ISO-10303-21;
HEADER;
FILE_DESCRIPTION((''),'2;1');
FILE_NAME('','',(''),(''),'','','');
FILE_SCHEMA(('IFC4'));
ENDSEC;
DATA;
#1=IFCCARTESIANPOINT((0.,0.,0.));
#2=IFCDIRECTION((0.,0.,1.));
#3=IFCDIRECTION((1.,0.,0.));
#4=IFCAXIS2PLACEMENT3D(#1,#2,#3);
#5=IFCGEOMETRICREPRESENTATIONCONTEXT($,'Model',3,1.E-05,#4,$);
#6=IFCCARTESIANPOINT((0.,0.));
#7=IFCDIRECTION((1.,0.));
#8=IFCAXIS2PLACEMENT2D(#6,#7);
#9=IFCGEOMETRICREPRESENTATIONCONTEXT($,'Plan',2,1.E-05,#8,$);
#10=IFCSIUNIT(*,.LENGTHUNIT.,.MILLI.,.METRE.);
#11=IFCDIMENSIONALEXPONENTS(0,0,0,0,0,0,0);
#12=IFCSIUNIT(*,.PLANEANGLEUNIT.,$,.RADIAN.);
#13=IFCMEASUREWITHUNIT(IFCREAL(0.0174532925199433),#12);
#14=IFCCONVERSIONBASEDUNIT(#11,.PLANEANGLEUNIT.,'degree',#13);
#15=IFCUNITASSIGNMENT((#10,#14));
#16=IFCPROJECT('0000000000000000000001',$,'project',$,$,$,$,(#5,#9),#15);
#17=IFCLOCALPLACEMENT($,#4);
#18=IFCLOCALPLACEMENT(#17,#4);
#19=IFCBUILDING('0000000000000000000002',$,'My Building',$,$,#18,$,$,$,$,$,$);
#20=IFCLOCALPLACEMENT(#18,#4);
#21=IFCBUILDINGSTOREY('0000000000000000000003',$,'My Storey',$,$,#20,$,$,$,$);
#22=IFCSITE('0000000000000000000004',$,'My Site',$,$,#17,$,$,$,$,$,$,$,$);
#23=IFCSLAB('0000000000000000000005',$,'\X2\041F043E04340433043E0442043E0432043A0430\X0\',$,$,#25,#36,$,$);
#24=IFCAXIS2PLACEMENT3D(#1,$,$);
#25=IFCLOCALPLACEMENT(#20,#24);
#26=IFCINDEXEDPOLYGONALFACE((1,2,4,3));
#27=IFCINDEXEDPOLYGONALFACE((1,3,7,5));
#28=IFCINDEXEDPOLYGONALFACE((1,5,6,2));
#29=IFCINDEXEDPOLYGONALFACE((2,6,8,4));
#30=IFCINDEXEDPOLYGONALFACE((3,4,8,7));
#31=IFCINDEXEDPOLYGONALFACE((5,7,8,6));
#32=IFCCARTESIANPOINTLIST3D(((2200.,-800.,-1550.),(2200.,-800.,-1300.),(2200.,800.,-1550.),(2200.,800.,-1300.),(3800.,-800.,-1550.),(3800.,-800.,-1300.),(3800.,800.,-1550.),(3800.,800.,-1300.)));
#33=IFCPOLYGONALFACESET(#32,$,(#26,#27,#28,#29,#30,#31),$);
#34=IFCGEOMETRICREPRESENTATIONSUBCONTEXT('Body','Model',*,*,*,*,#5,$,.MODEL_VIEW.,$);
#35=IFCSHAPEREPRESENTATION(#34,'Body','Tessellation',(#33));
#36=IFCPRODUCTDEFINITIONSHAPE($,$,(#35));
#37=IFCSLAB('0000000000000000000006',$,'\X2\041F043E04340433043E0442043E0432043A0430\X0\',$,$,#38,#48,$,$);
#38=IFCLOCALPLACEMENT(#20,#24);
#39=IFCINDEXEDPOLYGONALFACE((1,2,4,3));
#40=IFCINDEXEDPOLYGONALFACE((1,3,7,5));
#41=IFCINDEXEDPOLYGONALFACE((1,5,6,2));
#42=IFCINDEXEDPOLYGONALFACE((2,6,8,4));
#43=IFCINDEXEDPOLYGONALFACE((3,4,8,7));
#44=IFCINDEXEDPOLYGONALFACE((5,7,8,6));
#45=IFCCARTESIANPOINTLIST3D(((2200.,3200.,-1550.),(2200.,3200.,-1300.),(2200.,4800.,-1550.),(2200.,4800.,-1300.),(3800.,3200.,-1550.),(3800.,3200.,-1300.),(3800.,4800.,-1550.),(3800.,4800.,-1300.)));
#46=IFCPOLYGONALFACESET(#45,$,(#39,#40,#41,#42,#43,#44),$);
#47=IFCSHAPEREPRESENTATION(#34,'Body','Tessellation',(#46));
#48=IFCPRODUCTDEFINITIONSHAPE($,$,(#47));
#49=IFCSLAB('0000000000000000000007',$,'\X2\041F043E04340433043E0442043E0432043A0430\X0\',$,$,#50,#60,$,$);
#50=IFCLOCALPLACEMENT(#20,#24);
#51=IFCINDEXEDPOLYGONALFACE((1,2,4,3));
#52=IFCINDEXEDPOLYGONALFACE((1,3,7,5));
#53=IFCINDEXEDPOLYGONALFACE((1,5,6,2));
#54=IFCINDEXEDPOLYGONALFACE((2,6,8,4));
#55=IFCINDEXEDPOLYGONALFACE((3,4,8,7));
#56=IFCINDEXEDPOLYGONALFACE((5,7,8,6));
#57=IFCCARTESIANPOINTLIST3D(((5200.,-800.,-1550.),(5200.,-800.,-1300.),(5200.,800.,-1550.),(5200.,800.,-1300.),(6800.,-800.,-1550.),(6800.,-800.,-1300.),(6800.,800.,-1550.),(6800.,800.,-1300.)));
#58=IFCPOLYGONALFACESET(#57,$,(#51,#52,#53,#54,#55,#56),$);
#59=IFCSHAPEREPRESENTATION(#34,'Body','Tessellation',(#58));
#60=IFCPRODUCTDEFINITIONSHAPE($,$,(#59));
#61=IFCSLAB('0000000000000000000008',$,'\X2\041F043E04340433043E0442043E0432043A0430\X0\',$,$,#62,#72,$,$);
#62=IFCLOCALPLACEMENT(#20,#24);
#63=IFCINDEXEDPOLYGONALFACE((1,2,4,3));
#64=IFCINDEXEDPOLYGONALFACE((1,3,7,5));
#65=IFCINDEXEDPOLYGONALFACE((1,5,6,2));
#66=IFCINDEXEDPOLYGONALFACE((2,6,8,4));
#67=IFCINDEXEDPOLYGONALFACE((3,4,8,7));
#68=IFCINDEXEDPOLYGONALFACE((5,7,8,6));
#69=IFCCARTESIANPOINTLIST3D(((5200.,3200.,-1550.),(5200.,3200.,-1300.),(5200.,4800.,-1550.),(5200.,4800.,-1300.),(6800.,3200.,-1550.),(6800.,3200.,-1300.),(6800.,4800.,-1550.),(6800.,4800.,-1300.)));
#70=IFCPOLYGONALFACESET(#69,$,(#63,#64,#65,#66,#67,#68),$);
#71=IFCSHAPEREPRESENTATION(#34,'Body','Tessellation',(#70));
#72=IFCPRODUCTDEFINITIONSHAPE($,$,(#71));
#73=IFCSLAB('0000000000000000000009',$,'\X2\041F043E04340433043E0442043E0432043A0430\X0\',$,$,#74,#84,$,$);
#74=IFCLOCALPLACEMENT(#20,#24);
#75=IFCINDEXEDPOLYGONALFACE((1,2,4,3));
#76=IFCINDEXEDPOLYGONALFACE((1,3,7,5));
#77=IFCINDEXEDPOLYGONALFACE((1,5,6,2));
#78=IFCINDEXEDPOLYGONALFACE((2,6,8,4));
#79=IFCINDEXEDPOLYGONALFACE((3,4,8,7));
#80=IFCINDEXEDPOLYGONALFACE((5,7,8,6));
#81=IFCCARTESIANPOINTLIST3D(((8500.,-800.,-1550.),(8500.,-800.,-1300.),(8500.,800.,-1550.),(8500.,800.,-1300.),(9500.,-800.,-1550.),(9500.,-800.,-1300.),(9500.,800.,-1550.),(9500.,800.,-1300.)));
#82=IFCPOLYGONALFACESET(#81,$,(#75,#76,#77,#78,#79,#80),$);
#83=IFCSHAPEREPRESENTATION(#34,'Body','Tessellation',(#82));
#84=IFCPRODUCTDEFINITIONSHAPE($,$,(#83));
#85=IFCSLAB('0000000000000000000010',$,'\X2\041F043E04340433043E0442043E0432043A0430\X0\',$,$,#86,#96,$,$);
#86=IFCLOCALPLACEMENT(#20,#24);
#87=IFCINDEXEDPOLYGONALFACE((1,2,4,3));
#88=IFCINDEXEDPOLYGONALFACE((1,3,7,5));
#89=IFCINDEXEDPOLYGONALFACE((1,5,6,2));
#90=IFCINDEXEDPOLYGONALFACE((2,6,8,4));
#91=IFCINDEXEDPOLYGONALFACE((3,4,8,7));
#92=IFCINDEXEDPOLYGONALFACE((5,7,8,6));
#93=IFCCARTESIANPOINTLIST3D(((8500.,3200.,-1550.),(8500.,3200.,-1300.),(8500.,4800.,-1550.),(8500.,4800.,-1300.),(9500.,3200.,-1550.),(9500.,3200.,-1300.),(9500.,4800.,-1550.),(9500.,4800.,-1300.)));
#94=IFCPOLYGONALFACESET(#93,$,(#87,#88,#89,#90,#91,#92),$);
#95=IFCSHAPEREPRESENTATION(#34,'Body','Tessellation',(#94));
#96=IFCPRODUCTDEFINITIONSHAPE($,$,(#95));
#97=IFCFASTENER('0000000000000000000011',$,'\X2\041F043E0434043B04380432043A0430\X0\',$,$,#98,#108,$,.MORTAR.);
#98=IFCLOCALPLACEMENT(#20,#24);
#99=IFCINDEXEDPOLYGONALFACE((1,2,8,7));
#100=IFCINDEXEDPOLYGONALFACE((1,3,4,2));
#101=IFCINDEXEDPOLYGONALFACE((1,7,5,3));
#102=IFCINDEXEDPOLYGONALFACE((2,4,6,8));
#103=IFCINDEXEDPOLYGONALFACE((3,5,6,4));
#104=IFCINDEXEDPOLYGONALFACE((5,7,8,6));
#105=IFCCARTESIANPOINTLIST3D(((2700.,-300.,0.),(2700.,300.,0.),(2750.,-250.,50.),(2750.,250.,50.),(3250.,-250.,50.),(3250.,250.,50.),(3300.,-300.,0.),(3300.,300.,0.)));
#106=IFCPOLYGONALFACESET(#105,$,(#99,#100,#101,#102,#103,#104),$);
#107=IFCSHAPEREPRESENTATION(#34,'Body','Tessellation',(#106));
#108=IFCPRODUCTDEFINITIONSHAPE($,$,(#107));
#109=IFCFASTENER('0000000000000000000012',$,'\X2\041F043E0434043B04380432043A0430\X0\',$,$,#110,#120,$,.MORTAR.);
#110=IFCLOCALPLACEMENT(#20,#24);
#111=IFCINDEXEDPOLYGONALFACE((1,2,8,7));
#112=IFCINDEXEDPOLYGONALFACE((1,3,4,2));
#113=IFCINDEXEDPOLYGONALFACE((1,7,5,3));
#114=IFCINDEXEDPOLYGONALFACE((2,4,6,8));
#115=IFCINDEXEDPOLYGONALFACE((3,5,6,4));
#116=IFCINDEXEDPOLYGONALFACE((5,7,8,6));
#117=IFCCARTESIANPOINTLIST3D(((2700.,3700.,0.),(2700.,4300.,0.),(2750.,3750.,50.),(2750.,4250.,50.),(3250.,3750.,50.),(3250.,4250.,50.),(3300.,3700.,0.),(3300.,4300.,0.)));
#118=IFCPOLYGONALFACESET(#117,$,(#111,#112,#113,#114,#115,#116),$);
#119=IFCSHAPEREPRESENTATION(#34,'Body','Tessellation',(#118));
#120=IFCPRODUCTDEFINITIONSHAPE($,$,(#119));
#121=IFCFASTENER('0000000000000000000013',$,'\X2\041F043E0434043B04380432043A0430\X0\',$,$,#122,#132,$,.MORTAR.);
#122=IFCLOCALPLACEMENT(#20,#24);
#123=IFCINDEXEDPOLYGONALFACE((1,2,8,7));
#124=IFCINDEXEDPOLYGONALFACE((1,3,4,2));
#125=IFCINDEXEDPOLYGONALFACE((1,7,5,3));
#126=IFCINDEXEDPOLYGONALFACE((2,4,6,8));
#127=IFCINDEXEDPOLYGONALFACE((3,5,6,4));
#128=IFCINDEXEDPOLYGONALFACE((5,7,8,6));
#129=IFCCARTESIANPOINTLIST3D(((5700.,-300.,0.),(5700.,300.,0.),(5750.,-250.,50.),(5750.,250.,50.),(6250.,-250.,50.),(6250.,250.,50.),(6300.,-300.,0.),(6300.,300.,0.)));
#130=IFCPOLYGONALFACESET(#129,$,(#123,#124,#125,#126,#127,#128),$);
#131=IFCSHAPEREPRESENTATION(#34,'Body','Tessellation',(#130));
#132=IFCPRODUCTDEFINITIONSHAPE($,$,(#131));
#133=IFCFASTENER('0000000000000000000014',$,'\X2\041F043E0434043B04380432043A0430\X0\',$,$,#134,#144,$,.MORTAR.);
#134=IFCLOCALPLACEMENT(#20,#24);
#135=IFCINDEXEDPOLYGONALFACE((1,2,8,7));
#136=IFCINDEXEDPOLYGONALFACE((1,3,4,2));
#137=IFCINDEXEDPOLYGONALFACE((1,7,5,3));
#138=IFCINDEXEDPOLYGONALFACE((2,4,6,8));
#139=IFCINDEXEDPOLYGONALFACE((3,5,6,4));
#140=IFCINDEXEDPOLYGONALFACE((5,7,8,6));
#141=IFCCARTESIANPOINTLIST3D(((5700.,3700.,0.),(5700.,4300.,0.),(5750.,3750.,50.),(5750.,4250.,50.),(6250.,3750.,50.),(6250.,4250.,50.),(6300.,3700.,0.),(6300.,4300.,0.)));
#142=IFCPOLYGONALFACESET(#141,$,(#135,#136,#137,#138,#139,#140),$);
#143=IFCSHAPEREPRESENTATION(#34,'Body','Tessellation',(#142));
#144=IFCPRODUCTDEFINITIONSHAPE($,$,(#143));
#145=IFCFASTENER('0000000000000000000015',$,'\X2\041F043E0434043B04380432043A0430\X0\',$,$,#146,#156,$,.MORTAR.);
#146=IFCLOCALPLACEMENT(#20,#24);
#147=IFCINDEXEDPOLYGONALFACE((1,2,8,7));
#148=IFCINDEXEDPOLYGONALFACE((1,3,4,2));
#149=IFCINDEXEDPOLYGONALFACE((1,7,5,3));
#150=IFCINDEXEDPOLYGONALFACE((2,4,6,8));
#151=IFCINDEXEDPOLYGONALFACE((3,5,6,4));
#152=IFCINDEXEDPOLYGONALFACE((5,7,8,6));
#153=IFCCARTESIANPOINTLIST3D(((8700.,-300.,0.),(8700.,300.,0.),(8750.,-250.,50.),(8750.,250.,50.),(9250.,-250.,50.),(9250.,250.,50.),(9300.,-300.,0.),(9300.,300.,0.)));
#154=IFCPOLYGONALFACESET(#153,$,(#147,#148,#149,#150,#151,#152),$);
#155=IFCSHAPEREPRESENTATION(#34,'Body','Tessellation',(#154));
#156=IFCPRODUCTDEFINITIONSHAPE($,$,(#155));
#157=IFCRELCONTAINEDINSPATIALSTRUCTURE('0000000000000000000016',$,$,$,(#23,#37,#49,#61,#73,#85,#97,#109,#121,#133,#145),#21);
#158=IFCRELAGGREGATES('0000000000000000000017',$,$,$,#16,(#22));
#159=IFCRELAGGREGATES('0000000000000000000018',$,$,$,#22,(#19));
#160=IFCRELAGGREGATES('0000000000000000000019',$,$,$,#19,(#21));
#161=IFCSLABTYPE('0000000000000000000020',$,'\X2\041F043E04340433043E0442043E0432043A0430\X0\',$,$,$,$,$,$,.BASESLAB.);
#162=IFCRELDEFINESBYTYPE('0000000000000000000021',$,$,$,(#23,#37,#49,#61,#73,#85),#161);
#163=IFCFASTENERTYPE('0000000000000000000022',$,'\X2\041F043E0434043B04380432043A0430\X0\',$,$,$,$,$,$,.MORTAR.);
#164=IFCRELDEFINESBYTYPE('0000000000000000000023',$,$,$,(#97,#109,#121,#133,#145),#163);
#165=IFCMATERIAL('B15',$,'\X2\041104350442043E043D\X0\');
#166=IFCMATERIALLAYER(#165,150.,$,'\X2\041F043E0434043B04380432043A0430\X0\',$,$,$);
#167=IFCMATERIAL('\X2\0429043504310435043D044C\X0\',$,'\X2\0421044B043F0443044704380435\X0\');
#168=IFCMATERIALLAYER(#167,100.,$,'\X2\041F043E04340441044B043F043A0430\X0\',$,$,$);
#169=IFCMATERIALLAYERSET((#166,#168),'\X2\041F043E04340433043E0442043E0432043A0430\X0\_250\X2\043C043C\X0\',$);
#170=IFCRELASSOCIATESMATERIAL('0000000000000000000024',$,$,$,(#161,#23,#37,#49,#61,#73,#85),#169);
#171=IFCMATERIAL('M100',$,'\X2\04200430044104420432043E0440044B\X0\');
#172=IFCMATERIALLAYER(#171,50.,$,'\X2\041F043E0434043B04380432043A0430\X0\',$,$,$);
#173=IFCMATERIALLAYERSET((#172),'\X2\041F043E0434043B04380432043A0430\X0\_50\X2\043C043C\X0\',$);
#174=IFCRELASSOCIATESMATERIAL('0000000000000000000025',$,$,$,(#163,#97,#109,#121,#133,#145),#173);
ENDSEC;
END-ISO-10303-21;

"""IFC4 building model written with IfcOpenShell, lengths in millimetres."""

from ifc_helpers import new_model, entity, si_unit, converted_unit, frame, origin_with_axes, origin_2d_with_axis, place, context, subcontext, project, spatial, line, indexed_curve, outline, extrude, clip, halfspace, material, layer, layer_set, layer_usage, type_object, element, save


model = new_model("IFC4")

# Units and contexts
model_context = context("Model", 3, precision=1e-05, world=origin_with_axes())
plan_context = context("Plan", 2, precision=1e-05, world=origin_2d_with_axis())
body_context = subcontext(model_context, "Body", "Model", "MODEL_VIEW")
ifc_project = project(units=[si_unit("LENGTHUNIT", "METRE", prefix="MILLI"), converted_unit("PLANEANGLEUNIT", "degree", entity("IfcReal", 0.0174532925199433), si_unit("PLANEANGLEUNIT", "RADIAN"), dimensions=[0, 0, 0, 0, 0, 0, 0])], contexts=[model_context, plan_context])

# Site, building, storey
site_placement = place(None, origin_with_axes())
site = spatial("IfcSite", under=ifc_project, at=site_placement, Name="My Site")
building_placement = place(site_placement, origin_with_axes())
building = spatial("IfcBuilding", under=site, at=building_placement, Name="My Building")
storey_placement = place(building_placement, origin_with_axes())
storey = spatial("IfcBuildingStorey", under=building, at=storey_placement, Name="My Storey")

# Slabs
ifc_material_1 = material(Name="B15", Category="Бетон")
ifc_layer_1 = layer(ifc_material_1, 150.0, Name="Подливка")
ifc_material_2 = material(Name="Щебень", Category="Сыпучие")
ifc_layer_2 = layer(ifc_material_2, 100.0, Name="Подсыпка")
ifc_layer_set_1 = layer_set([ifc_layer_1, ifc_layer_2], Name="Подготовка_250мм")
ifc_layer_usage_1 = layer_usage(ifc_layer_set_1, "AXIS3", "NEGATIVE", 0.0)
slab_type = type_object("IfcSlabType", Name="Подготовка", PredefinedType="BASESLAB", material=ifc_layer_set_1)
slab_1_placement = place(storey_placement, frame((3000.0, 0.0, -1550.0), z_axis=(0.0, 0.0, 1.0), x_axis=(1.0, 0.0, 0.0)))
element("IfcSlab", 1, at=slab_1_placement, inside=storey, type_object=slab_type, material=ifc_layer_usage_1, Name="Подготовка", context=body_context, shape_type="SweptSolid", body=[
    extrude(outline(indexed_curve([(800.0, 800.0), (800.0, -800.0), (-800.0, -800.0), (-800.0, 800.0)], segments=[line(3, 2), line(2, 1), line(1, 4), line(4, 3)], self_intersect=False)), None, (0.0, 0.0, 1.0), 250.0),
])
slab_2_placement = place(storey_placement, frame((3000.0, 4000.0, -1550.0), z_axis=(0.0, 0.0, 1.0), x_axis=(1.0, 0.0, 0.0)))
element("IfcSlab", 2, at=slab_2_placement, inside=storey, type_object=slab_type, material=ifc_layer_usage_1, Name="Подготовка", context=body_context, shape_type="SweptSolid", body=[
    extrude(outline(indexed_curve([(-800.0, -800.0), (800.0, -800.0), (800.0, 800.0), (-800.0, 800.0)], segments=[line(3, 2), line(2, 1), line(1, 4), line(4, 3)], self_intersect=False)), None, (0.0, 0.0, 1.0), 250.0),
])
for number, where, z_axis, x_axis, name in (
    (3, (6000.0, 0.0, -1550.0), (0.0, 0.0, 1.0), (1.0, 0.0, 0.0), "Подготовка"),
    (4, (6000.0, 4000.0, -1550.0), (0.0, 0.0, 1.0), (1.0, 0.0, 0.0), "Подготовка"),
):
    element("IfcSlab", number, at=place(storey_placement, frame(where, z_axis=z_axis, x_axis=x_axis)), inside=storey, type_object=slab_type, material=ifc_layer_usage_1, Name=name, context=body_context, shape_type="SweptSolid", body=[
        extrude(outline(indexed_curve([(800.0, 800.0), (800.0, -800.0), (-800.0, -800.0), (-800.0, 800.0)], segments=[line(3, 2), line(2, 1), line(1, 4), line(4, 3)], self_intersect=False)), None, (0.0, 0.0, 1.0), 250.0),
    ])
slab_3_placement = place(storey_placement, frame((9000.0, 0.0, -1550.0), z_axis=(0.0, 0.0, 1.0), x_axis=(1.0, 0.0, 0.0)))
element("IfcSlab", 5, at=slab_3_placement, inside=storey, type_object=slab_type, material=ifc_layer_usage_1, Name="Подготовка", context=body_context, shape_type="SweptSolid", body=[
    extrude(outline(indexed_curve([(500.0, 800.0), (500.0, -800.0), (-500.0, -800.0), (-500.0, 800.0)], segments=[line(3, 2), line(2, 1), line(1, 4), line(4, 3)], self_intersect=False)), None, (0.0, 0.0, 1.0), 250.0),
])
slab_4_placement = place(storey_placement, frame((9000.0, 4000.0, -1550.0), z_axis=(0.0, 0.0, 1.0), x_axis=(1.0, 0.0, 0.0)))
element("IfcSlab", 6, at=slab_4_placement, inside=storey, type_object=slab_type, material=ifc_layer_usage_1, Name="Подготовка", context=body_context, shape_type="SweptSolid", body=[
    extrude(outline(indexed_curve([(-500.0, -800.0), (500.0, -800.0), (500.0, 800.0), (-500.0, 800.0)], segments=[line(3, 2), line(2, 1), line(1, 4), line(4, 3)], self_intersect=False)), None, (0.0, 0.0, 1.0), 250.0),
])

# Fasteners
ifc_material_3 = material(Name="M100", Category="Растворы")
ifc_layer_3 = layer(ifc_material_3, 50.0, Name="Подливка")
ifc_layer_set_2 = layer_set([ifc_layer_3], Name="Подливка_50мм")
ifc_layer_usage_2 = layer_usage(ifc_layer_set_2, "AXIS3", "POSITIVE", 0.0)
fastener_type = type_object("IfcFastenerType", Name="Подливка", PredefinedType="MORTAR", material=ifc_layer_set_2)
placement = place(storey_placement, frame((3000.0, 0.0, 0.0), z_axis=(0.0, 0.0, 1.0), x_axis=(1.0, 0.0, 0.0)))
element("IfcFastener", 7, at=placement, inside=storey, type_object=fastener_type, material=ifc_layer_usage_2, Name="Подливка", PredefinedType="MORTAR", context=body_context, shape_type="Clipping", body=[
    clip(clip(clip(clip(extrude(outline(indexed_curve([(-300.0, -300.0), (300.0, -300.0), (300.0, 300.0), (-300.0, 300.0)], segments=[line(3, 2), line(2, 1), line(1, 4), line(4, 3)], self_intersect=False)), None, (0.0, 0.0, 1.0), 50.0), halfspace(frame((-53.6, 200.0, 353.6), z_axis=(0.707107, 0.0, 0.707107), x_axis=(0.707107, 0.0, -0.707107)), False)), halfspace(frame((-200.0, -53.6, 353.6), z_axis=(0.0, 0.707107, 0.707107), x_axis=(0.0, 0.707107, -0.707107)), False)), halfspace(frame((200.0, 53.6, 353.6), z_axis=(0.0, -0.707107, 0.707107), x_axis=(0.0, -0.707107, -0.707107)), False)), halfspace(frame((53.6, 200.0, 353.6), z_axis=(-0.707107, 0.0, 0.707107), x_axis=(-0.707107, 0.0, -0.707107)), False)),
])
fastener_1_placement = place(storey_placement, frame((3000.0, 4000.0, 0.0), z_axis=(0.0, 0.0, 1.0), x_axis=(1.0, 0.0, 0.0)))
element("IfcFastener", 8, at=fastener_1_placement, inside=storey, type_object=fastener_type, material=ifc_layer_usage_2, Name="Подливка", PredefinedType="MORTAR", context=body_context, shape_type="Clipping", body=[
    clip(clip(clip(clip(extrude(outline(indexed_curve([(-300.0, -300.0), (300.0, -300.0), (300.0, 300.0), (-300.0, 300.0)], segments=[line(3, 2), line(2, 1), line(1, 4), line(4, 3)], self_intersect=False)), None, (0.0, 0.0, 1.0), 50.0), halfspace(frame((-53.6, 200.0, 353.6), z_axis=(0.707107, 0.0, 0.707107), x_axis=(0.707107, 0.0, -0.707107)), False)), halfspace(frame((-200.0, -53.6, 353.6), z_axis=(0.0, 0.707107, 0.707107), x_axis=(0.0, 0.707107, -0.707107)), False)), halfspace(frame((200.0, 53.6, 353.6), z_axis=(0.0, -0.707107, 0.707107), x_axis=(0.0, -0.707107, -0.707107)), False)), halfspace(frame((53.6, 200.0, 353.6), z_axis=(-0.707107, 0.0, 0.707107), x_axis=(-0.707107, 0.0, -0.707107)), False)),
])
fastener_2_placement = place(storey_placement, frame((6000.0, 0.0, 0.0), z_axis=(0.0, 0.0, 1.0), x_axis=(1.0, 0.0, 0.0)))
element("IfcFastener", 9, at=fastener_2_placement, inside=storey, type_object=fastener_type, material=ifc_layer_usage_2, Name="Подливка", PredefinedType="MORTAR", context=body_context, shape_type="Clipping", body=[
    clip(clip(clip(clip(extrude(outline(indexed_curve([(-300.0, -300.0), (300.0, -300.0), (300.0, 300.0), (-300.0, 300.0)], segments=[line(3, 2), line(2, 1), line(1, 4), line(4, 3)], self_intersect=False)), None, (0.0, 0.0, 1.0), 50.0), halfspace(frame((-53.6, 200.0, 353.6), z_axis=(0.707107, 0.0, 0.707107), x_axis=(0.707107, 0.0, -0.707107)), False)), halfspace(frame((-200.0, -53.6, 353.6), z_axis=(0.0, 0.707107, 0.707107), x_axis=(0.0, 0.707107, -0.707107)), False)), halfspace(frame((200.0, 53.6, 353.6), z_axis=(0.0, -0.707107, 0.707107), x_axis=(0.0, -0.707107, -0.707107)), False)), halfspace(frame((53.6, 200.0, 353.6), z_axis=(-0.707107, 0.0, 0.707107), x_axis=(-0.707107, 0.0, -0.707107)), False)),
])
fastener_3_placement = place(storey_placement, frame((6000.0, 4000.0, 0.0), z_axis=(0.0, 0.0, 1.0), x_axis=(1.0, 0.0, 0.0)))
element("IfcFastener", 10, at=fastener_3_placement, inside=storey, type_object=fastener_type, material=ifc_layer_usage_2, Name="Подливка", PredefinedType="MORTAR", context=body_context, shape_type="Clipping", body=[
    clip(clip(clip(clip(extrude(outline(indexed_curve([(-300.0, -300.0), (300.0, -300.0), (300.0, 300.0), (-300.0, 300.0)], segments=[line(3, 2), line(2, 1), line(1, 4), line(4, 3)], self_intersect=False)), None, (0.0, 0.0, 1.0), 50.0), halfspace(frame((-53.6, 200.0, 353.6), z_axis=(0.707107, 0.0, 0.707107), x_axis=(0.707107, 0.0, -0.707107)), False)), halfspace(frame((-200.0, -53.6, 353.6), z_axis=(0.0, 0.707107, 0.707107), x_axis=(0.0, 0.707107, -0.707107)), False)), halfspace(frame((200.0, 53.6, 353.6), z_axis=(0.0, -0.707107, 0.707107), x_axis=(0.0, -0.707107, -0.707107)), False)), halfspace(frame((53.6, 200.0, 353.6), z_axis=(-0.707107, 0.0, 0.707107), x_axis=(-0.707107, 0.0, -0.707107)), False)),
])
fastener_4_placement = place(storey_placement, frame((9000.0, 0.0, 0.0), z_axis=(0.0, 0.0, 1.0), x_axis=(1.0, 0.0, 0.0)))
element("IfcFastener", 11, at=fastener_4_placement, inside=storey, type_object=fastener_type, material=ifc_layer_usage_2, Name="Подливка", PredefinedType="MORTAR", context=body_context, shape_type="Clipping", body=[
    clip(clip(clip(clip(extrude(outline(indexed_curve([(-300.0, -300.0), (300.0, -300.0), (300.0, 300.0), (-300.0, 300.0)], segments=[line(3, 2), line(2, 1), line(1, 4), line(4, 3)], self_intersect=False)), None, (0.0, 0.0, 1.0), 50.0), halfspace(frame((-53.6, 200.0, 353.6), z_axis=(0.707107, 0.0, 0.707107), x_axis=(0.707107, 0.0, -0.707107)), False)), halfspace(frame((-200.0, -53.6, 353.6), z_axis=(0.0, 0.707107, 0.707107), x_axis=(0.0, 0.707107, -0.707107)), False)), halfspace(frame((200.0, 53.6, 353.6), z_axis=(0.0, -0.707107, 0.707107), x_axis=(0.0, -0.707107, -0.707107)), False)), halfspace(frame((53.6, 200.0, 353.6), z_axis=(-0.707107, 0.0, 0.707107), x_axis=(-0.707107, 0.0, -0.707107)), False)),
])

save(model, "model.ifc")
